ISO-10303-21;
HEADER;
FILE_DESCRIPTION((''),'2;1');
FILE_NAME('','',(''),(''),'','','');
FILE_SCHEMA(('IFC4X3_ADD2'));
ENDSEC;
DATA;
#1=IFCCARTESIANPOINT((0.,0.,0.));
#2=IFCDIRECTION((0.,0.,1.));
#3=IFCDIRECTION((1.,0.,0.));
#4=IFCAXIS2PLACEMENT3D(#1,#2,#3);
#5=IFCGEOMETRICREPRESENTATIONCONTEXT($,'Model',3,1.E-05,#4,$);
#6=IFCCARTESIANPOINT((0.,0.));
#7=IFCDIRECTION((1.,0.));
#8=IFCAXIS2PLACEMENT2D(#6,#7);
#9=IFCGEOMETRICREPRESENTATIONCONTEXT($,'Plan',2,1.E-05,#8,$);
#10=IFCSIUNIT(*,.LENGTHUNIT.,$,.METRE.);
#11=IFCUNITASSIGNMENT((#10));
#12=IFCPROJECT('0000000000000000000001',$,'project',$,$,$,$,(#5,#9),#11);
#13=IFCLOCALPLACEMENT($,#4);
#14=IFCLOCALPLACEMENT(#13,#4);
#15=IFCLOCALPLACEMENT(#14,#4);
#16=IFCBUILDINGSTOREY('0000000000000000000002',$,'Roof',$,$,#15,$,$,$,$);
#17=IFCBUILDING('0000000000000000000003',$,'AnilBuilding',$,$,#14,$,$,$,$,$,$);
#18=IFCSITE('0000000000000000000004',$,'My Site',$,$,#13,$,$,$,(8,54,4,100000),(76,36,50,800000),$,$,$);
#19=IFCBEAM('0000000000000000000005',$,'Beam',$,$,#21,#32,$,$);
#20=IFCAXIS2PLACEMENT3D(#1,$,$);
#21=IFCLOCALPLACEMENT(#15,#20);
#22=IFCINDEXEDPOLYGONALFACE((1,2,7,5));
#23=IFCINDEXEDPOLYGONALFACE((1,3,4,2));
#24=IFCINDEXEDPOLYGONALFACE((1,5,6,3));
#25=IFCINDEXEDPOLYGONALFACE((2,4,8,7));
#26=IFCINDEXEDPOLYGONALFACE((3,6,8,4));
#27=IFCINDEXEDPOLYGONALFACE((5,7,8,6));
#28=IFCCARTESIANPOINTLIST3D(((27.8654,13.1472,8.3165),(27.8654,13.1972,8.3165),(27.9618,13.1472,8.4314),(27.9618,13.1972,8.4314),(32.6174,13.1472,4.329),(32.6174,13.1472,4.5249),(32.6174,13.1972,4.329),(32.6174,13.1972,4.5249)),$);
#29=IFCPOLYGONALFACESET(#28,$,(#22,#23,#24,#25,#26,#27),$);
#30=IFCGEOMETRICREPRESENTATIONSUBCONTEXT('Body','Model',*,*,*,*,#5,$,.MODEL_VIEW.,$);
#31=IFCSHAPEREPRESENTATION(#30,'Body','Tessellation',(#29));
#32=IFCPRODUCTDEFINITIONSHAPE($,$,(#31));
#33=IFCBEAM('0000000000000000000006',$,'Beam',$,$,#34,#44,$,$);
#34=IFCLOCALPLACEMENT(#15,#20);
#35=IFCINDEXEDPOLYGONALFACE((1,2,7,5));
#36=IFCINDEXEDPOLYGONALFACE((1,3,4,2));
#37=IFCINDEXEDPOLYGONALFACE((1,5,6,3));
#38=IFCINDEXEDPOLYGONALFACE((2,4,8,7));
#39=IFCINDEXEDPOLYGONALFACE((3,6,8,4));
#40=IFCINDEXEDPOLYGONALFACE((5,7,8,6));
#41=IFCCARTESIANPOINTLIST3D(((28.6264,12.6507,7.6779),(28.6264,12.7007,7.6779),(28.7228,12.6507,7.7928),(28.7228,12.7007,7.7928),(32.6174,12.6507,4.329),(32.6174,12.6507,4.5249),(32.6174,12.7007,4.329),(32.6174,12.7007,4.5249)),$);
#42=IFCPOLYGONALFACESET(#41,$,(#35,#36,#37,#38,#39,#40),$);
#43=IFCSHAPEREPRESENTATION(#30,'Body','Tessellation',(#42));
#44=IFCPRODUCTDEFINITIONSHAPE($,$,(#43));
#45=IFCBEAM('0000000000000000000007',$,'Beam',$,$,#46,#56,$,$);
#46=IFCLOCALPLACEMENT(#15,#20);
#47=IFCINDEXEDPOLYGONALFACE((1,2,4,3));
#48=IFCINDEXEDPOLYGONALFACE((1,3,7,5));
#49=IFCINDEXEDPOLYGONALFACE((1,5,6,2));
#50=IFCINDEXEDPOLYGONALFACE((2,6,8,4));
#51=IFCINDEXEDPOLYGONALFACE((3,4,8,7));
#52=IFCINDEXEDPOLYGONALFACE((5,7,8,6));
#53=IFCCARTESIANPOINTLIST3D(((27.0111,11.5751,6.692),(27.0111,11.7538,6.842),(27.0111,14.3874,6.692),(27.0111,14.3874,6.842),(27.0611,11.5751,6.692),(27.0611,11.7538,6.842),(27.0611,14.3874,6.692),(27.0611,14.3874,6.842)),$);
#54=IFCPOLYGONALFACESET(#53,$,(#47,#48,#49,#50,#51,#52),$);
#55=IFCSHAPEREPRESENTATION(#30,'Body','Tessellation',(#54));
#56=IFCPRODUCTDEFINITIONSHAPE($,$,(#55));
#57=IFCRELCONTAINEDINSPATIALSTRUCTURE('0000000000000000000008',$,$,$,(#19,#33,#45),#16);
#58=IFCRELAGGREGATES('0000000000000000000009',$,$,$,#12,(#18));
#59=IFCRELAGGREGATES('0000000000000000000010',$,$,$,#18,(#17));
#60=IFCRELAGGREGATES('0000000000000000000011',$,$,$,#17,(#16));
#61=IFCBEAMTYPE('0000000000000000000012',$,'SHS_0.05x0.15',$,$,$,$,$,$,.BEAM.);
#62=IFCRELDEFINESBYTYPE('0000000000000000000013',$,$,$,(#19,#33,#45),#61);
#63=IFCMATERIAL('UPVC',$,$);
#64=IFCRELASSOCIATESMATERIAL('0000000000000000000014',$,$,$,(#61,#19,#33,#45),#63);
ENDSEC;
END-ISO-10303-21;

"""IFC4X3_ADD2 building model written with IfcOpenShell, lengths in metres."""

from ifc_helpers import new_model, si_unit, frame, origin_with_axes, origin_2d_with_axis, place, context, subcontext, project, spatial, indexed_curve, outline, extrude, clip, halfspace, material, material_profile, profile_set, profile_usage, type_object, element, save


model = new_model("IFC4X3_ADD2")

# Units and contexts
model_context = context("Model", 3, precision=1e-05, world=origin_with_axes())
plan_context = context("Plan", 2, precision=1e-05, world=origin_2d_with_axis())
body_context_1 = subcontext(model_context, "Body", "Model", "MODEL_VIEW")
ifc_project = project(units=[si_unit("LENGTHUNIT", "METRE")], contexts=[model_context, plan_context])

# Site, building, storey
site_placement = place(None, origin_with_axes())
site = spatial("IfcSite", under=ifc_project, at=site_placement, Name="My Site", RefLatitude=(8, 54, 4, 100000), RefLongitude=(76, 36, 50, 800000))
building_placement = place(site_placement, origin_with_axes())
building = spatial("IfcBuilding", under=site, at=building_placement, Name="AnilBuilding")
storey_placement = place(building_placement, origin_with_axes())
storey = spatial("IfcBuildingStorey", under=building, at=storey_placement, Name="Roof")

# Beams
ifc_material_1 = material(Name="UPVC")
ifc_material_profile_1 = material_profile(ifc_material_1, outline(indexed_curve([(-0.025, 0.075), (0.025, 0.075), (0.025, -0.075), (-0.025, -0.075), (-0.025, 0.075)])))
ifc_profile_set_1 = profile_set([ifc_material_profile_1])
beam_type = type_object("IfcBeamType", Name="SHS_0.05x0.15", PredefinedType="BEAM", material=ifc_profile_set_1)
ifc_profile_usage_1 = profile_usage(ifc_profile_set_1, cardinal=5)
beam_1_placement = place(storey_placement, frame((32.7323, 13.1722, 4.3305), z_axis=(-0.766045, 0.000001, 0.642788), x_axis=(-0.000001, -1.0, 0.0)))
element("IfcBeam", 1, at=beam_1_placement, inside=storey, type_object=beam_type, material=ifc_profile_usage_1, Name="Beam", context=body_context_1, shape_type="Clipping", body=[
    clip(extrude(outline(indexed_curve([(-0.025, 0.075), (0.025, 0.075), (0.025, -0.075), (-0.025, -0.075), (-0.025, 0.075)])), origin_with_axes(), (0.0, 0.0, 1.0), 6.2904), halfspace(frame((5.7998, 0.0185, 0.1655), z_axis=(0.0, 0.642788, -0.766044), x_axis=(1.0, 0.0, 0.0)), False)),
])
ifc_profile_usage_2 = profile_usage(ifc_profile_set_1, cardinal=5)
beam_2_placement = place(storey_placement, frame((32.7323, 12.6757, 4.3305), z_axis=(-0.766045, 0.000001, 0.642788), x_axis=(-0.000001, -1.0, 0.0)))
element("IfcBeam", 2, at=beam_2_placement, inside=storey, type_object=beam_type, material=ifc_profile_usage_2, Name="Beam", context=body_context_1, shape_type="Clipping", body=[
    clip(extrude(outline(indexed_curve([(-0.025, 0.075), (0.025, 0.075), (0.025, -0.075), (-0.025, -0.075), (-0.025, 0.075)])), origin_with_axes(), (0.0, 0.0, 1.0), 5.2969), halfspace(frame((4.9998, 0.0185, 0.1655), z_axis=(0.0, 0.642788, -0.766044), x_axis=(1.0, 0.0, 0.0)), False)),
])
ifc_profile_usage_3 = profile_usage(ifc_profile_set_1, cardinal=5)
beam_3_placement = place(storey_placement, frame((27.0361, 11.5144, 6.767), z_axis=(0.000001, 1.0, 0.0), x_axis=(-1.0, 0.000001, 0.0)))
element("IfcBeam", 3, at=beam_3_placement, inside=storey, type_object=beam_type, material=ifc_profile_usage_3, Name="Beam", context=body_context_1, shape_type="Clipping", body=[
    clip(extrude(outline(indexed_curve([(-0.025, 0.075), (0.025, 0.075), (0.025, -0.075), (-0.025, -0.075), (-0.025, 0.075)])), origin_with_axes(), (0.0, 0.0, 1.0), 2.873), halfspace(frame((0.0, -3.91, -4.5098), z_axis=(0.0, 0.766045, -0.642787), x_axis=(1.0, 0.0, 0.0)), False)),
])

save(model, "model.ifc")
